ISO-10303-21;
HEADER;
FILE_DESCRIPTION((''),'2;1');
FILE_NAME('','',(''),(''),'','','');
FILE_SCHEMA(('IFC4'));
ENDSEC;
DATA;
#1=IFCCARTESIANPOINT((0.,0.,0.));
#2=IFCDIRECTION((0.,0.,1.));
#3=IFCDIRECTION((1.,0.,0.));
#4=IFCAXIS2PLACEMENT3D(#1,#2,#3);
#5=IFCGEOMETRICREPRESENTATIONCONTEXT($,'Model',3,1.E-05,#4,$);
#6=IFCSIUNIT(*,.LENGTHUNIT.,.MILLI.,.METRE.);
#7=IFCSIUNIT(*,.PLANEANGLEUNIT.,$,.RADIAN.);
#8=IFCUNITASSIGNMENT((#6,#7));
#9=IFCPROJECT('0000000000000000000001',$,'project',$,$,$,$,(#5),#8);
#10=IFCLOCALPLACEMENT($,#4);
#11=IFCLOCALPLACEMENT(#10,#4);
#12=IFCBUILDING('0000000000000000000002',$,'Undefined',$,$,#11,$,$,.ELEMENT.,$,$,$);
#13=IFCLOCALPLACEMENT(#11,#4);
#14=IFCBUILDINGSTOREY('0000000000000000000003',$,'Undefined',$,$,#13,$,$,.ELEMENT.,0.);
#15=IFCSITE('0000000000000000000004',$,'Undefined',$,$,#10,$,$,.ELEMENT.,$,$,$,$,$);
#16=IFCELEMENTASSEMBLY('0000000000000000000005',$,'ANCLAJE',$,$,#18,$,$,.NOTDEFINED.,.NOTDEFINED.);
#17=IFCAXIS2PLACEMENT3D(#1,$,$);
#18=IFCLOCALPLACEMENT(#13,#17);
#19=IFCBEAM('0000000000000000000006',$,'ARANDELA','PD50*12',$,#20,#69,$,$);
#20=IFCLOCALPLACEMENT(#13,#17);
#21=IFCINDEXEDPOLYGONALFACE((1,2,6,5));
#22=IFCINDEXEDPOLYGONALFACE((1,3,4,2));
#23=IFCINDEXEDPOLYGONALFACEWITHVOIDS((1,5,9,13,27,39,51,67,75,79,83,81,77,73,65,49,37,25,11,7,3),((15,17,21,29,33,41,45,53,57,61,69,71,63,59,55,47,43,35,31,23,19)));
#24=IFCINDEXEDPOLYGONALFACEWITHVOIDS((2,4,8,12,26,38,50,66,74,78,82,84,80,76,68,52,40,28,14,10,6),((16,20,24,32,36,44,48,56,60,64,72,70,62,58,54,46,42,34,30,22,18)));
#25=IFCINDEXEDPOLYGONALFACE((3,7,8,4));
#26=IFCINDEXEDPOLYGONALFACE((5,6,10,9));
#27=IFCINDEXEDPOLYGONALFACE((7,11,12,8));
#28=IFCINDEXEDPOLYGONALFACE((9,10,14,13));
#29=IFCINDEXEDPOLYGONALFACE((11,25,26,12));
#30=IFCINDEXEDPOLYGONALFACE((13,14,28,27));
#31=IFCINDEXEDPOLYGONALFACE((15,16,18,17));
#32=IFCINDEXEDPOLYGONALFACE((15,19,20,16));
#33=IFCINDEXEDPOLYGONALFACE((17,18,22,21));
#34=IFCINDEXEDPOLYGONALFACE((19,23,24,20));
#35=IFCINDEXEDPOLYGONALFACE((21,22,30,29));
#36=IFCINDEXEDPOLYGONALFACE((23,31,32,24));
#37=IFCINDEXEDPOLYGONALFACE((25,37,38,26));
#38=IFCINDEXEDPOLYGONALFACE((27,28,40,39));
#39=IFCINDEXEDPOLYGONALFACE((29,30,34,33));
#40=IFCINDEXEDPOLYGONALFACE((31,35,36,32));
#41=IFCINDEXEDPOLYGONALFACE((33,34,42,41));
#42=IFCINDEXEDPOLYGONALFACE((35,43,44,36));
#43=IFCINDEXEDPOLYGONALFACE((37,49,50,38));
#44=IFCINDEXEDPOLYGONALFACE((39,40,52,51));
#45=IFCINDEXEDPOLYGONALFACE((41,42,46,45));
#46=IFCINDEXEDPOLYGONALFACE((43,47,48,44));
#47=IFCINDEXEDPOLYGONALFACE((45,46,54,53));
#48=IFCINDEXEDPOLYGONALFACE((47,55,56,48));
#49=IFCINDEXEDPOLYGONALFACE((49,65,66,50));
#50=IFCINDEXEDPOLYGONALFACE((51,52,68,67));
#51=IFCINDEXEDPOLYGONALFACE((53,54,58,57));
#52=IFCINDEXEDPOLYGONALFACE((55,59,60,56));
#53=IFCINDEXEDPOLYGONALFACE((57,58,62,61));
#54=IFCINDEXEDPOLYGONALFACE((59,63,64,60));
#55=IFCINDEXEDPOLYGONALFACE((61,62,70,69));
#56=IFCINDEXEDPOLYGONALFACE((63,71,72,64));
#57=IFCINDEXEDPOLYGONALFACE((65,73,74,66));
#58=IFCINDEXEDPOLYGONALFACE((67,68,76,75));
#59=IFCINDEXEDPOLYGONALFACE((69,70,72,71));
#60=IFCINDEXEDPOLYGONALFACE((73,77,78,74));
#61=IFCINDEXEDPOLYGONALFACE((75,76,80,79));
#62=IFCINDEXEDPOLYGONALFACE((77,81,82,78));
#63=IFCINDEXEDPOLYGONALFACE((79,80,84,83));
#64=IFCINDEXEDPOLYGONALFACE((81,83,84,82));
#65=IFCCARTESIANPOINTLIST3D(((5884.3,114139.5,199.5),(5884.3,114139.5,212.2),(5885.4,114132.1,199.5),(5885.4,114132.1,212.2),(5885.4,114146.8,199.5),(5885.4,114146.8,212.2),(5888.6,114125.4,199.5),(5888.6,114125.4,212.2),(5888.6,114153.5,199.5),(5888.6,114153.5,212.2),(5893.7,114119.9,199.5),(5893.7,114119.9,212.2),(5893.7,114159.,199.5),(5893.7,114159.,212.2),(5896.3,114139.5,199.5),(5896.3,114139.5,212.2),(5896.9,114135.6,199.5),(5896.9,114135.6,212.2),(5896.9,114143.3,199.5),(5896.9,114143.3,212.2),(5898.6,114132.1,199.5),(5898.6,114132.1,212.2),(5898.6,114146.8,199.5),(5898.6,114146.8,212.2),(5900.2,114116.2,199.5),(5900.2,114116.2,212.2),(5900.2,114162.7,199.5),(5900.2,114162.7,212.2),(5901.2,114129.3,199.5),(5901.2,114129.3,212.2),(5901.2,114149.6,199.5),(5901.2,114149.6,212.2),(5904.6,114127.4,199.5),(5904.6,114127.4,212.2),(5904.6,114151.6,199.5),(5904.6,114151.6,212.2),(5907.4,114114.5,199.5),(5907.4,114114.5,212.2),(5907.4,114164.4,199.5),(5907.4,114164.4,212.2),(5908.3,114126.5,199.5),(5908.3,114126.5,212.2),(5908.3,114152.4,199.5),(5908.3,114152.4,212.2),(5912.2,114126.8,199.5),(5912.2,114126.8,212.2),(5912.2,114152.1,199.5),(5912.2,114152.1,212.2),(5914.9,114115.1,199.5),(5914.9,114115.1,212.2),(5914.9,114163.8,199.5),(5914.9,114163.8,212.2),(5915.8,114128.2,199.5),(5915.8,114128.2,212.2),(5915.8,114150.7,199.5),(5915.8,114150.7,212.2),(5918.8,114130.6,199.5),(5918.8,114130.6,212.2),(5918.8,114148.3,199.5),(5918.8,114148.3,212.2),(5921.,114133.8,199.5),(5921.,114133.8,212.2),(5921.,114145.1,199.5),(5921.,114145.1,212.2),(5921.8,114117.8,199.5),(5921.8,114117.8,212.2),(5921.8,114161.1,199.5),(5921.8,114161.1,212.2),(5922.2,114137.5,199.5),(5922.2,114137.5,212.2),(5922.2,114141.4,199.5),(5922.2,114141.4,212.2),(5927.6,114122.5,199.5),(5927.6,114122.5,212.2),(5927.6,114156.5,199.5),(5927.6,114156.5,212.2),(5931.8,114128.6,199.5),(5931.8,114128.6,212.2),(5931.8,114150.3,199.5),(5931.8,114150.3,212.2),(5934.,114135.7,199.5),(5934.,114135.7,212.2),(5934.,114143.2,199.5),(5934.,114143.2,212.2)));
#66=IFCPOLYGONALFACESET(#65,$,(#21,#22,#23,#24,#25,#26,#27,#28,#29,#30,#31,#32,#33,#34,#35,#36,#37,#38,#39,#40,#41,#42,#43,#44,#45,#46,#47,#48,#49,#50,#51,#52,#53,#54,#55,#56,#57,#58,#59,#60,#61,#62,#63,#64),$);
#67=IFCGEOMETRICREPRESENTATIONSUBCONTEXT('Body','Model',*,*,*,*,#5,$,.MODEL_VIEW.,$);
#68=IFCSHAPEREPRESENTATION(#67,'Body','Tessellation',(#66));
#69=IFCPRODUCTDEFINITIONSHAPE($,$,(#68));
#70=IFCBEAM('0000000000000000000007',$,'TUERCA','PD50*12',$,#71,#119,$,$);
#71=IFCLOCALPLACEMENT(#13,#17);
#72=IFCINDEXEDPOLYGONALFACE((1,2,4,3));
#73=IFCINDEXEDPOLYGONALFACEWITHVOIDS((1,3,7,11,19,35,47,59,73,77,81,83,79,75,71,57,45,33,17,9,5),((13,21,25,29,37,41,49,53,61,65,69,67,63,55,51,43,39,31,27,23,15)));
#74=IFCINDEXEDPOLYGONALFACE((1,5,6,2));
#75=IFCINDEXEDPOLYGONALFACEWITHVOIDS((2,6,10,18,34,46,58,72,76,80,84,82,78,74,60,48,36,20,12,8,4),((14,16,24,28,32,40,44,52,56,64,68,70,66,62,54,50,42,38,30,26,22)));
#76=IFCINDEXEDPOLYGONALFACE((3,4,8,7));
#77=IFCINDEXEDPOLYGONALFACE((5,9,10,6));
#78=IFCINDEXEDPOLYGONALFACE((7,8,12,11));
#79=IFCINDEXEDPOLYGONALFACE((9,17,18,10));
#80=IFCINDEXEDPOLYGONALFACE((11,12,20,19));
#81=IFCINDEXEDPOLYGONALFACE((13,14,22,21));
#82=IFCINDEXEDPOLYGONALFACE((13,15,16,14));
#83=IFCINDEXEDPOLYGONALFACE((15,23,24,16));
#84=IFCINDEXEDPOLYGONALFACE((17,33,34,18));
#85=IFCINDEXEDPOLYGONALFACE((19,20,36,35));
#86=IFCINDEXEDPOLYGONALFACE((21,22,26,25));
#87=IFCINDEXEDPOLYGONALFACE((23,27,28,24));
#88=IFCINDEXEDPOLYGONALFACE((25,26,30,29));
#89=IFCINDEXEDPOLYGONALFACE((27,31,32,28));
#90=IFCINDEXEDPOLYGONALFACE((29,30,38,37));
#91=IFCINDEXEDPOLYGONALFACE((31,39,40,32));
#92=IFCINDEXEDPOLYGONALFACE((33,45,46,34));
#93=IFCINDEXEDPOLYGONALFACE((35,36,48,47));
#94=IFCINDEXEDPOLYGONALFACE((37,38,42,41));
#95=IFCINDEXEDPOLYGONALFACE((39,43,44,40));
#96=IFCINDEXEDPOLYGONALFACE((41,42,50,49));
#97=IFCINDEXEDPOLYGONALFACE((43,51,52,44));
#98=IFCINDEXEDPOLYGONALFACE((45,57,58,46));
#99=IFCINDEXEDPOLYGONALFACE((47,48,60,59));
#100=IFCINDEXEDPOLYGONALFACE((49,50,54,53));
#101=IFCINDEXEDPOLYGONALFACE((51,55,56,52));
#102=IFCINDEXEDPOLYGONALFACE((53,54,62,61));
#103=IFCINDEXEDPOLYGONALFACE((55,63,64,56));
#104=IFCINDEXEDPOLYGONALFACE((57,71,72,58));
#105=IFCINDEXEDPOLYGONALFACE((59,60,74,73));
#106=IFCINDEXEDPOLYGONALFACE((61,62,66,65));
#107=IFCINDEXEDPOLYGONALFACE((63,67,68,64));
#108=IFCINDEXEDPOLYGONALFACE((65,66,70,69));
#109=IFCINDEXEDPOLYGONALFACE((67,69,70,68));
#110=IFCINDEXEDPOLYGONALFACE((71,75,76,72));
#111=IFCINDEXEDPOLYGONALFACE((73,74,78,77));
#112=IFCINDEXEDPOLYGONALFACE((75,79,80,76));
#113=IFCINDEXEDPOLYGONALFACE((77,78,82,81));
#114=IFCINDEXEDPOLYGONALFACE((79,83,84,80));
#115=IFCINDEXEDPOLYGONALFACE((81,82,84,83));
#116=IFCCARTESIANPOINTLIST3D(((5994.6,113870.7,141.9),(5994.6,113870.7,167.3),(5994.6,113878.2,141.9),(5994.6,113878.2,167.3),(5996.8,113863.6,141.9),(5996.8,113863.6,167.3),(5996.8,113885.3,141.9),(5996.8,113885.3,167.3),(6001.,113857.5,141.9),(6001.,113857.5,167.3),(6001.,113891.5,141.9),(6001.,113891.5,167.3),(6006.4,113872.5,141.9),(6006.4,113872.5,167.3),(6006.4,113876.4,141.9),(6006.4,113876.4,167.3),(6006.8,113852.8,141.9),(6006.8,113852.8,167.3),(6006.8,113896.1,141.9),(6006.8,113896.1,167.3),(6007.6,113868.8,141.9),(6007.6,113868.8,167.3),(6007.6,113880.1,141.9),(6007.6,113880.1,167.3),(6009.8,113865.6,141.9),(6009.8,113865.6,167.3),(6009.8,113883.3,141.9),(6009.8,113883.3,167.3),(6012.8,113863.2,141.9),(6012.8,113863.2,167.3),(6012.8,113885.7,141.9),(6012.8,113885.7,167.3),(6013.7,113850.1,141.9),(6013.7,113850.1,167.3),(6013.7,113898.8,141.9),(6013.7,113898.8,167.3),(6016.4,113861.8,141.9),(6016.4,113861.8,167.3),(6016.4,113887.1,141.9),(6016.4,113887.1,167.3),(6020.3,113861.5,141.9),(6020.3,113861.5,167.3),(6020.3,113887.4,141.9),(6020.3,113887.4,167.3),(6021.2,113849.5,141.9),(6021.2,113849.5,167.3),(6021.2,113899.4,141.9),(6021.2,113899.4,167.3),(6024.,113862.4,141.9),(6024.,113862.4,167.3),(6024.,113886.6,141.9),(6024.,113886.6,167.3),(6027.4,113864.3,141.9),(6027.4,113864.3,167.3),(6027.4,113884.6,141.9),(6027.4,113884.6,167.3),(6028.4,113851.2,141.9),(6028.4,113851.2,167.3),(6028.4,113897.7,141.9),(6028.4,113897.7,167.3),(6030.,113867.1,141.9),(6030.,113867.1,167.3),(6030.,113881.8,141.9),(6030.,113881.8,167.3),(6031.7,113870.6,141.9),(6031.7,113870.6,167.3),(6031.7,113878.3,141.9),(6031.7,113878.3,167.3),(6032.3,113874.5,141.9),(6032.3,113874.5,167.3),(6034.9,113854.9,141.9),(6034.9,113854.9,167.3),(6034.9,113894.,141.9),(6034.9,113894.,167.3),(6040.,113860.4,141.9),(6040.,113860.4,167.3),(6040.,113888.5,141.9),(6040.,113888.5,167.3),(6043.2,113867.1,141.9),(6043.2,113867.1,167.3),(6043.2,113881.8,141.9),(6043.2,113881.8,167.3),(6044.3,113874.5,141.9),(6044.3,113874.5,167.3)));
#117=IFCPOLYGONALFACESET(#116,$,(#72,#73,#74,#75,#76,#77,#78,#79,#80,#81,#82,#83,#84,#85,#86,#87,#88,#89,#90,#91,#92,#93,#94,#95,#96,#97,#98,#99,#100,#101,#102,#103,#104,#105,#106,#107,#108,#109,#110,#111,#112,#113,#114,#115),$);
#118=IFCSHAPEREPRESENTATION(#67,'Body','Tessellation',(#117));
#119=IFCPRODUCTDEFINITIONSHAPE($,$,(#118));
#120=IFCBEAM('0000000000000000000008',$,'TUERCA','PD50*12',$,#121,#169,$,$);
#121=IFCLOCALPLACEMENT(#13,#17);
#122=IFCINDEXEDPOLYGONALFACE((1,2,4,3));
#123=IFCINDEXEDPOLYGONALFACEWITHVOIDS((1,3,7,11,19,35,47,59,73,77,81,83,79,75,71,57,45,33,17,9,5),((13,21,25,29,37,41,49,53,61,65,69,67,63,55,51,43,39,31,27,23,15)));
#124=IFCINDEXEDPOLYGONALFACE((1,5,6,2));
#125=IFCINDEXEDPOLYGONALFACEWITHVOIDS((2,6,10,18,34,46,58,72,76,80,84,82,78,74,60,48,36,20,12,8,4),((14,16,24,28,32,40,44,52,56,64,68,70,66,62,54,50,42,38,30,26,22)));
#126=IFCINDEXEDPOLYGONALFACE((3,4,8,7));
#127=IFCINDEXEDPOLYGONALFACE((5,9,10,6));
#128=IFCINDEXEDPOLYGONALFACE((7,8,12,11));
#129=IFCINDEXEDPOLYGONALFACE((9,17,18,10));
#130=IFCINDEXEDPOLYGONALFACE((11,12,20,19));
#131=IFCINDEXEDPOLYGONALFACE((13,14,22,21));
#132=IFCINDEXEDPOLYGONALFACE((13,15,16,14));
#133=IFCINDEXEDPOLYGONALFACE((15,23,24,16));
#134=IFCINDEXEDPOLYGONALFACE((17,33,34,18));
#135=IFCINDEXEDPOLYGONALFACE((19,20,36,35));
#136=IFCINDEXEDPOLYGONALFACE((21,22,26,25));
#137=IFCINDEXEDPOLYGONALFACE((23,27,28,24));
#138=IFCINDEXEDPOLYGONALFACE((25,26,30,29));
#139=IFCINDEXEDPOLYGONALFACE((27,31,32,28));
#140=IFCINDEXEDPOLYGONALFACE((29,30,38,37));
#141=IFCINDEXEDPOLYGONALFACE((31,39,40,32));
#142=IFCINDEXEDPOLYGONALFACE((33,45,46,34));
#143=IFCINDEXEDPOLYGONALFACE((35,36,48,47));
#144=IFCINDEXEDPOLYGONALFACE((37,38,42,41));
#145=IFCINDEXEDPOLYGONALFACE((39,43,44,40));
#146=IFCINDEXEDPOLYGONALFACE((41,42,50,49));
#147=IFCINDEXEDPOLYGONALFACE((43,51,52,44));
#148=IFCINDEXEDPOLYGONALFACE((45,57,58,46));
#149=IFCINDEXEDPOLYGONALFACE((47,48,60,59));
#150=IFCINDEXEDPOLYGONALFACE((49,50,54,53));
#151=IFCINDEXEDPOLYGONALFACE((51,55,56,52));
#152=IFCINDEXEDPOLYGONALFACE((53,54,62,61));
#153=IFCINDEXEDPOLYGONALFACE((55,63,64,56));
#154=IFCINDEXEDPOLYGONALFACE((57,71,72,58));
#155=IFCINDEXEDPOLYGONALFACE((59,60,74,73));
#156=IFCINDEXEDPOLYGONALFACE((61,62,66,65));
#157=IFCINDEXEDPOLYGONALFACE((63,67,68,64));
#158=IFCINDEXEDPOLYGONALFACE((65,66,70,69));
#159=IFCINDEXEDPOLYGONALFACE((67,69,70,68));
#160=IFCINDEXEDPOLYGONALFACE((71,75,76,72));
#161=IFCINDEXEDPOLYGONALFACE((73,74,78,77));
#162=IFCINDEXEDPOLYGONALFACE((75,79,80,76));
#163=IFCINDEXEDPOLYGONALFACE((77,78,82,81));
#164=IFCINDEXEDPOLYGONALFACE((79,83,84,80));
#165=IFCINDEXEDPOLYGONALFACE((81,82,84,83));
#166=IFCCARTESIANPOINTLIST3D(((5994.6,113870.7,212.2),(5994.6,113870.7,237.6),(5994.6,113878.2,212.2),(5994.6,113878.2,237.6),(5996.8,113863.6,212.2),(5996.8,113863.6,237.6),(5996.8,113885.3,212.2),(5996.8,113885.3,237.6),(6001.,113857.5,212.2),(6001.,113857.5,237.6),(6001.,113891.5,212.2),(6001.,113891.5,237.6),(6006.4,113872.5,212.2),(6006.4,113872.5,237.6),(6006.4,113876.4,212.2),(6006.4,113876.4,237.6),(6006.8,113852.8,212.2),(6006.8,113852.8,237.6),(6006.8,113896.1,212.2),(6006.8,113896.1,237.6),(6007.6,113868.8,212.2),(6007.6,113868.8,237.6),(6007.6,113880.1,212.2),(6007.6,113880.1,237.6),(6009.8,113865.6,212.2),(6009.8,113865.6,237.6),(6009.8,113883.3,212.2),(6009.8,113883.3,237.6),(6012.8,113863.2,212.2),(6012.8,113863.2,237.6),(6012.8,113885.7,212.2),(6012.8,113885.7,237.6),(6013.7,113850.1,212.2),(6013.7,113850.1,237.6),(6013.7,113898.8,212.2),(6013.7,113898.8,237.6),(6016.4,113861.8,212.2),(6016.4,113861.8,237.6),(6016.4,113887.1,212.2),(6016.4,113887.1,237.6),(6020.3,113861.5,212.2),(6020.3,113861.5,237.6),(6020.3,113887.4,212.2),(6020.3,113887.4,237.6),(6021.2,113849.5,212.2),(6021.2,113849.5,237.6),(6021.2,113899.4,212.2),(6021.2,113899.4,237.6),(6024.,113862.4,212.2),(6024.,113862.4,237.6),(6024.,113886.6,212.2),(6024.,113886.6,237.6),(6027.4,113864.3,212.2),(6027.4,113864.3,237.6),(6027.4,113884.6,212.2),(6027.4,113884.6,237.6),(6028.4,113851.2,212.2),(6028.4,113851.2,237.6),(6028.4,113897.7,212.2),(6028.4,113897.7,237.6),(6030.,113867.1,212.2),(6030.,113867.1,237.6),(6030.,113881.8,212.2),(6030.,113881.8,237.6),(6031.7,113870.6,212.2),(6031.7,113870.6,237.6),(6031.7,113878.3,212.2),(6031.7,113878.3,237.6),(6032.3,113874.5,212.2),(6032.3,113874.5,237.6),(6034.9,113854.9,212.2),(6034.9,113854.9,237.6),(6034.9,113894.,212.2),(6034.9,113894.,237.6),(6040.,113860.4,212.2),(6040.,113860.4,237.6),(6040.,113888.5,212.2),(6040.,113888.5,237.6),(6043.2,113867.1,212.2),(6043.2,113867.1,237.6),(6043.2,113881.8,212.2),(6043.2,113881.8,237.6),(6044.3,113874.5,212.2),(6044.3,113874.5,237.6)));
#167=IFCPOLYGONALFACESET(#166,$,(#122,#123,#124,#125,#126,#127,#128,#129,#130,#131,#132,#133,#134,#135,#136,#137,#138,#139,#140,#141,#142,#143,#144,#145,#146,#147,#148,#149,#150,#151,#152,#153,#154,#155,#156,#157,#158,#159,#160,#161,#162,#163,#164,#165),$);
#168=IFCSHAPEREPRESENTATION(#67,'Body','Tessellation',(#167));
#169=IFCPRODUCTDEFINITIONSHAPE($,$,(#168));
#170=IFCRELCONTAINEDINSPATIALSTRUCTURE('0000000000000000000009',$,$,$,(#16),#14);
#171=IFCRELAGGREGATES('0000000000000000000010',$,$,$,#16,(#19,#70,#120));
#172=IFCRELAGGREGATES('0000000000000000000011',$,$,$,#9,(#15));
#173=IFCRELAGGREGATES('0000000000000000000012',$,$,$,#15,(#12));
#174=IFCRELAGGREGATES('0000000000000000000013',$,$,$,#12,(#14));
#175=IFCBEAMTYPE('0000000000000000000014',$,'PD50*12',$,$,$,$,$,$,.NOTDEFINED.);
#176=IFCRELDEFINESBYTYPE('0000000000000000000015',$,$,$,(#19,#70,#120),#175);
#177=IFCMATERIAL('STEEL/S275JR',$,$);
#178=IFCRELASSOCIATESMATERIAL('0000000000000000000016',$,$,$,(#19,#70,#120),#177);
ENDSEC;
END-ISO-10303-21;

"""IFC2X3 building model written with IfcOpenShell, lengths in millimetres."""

from ifc_helpers import new_model, si_unit, frame, origin_with_axes, origin_2d_with_axis, place, context, subcontext, project, spatial, hollow_circle, extrude, material, type_object, element, aggregate, save


model = new_model("IFC2X3")

# Units and contexts
model_context = context("Model", 3, precision=1e-05, world=origin_with_axes())
body_context = subcontext(model_context, "Body", "Model", "MODEL_VIEW")
ifc_project = project(units=[si_unit("LENGTHUNIT", "METRE", prefix="MILLI"), si_unit("PLANEANGLEUNIT", "RADIAN")], contexts=[model_context])

# Site, building, storey
site_placement = place(None, origin_with_axes())
site = spatial("IfcSite", under=ifc_project, at=site_placement, Name="Undefined", CompositionType="ELEMENT")
building_placement = place(site_placement, origin_with_axes())
building = spatial("IfcBuilding", under=site, at=building_placement, Name="Undefined", CompositionType="ELEMENT")
storey_placement = place(building_placement, origin_with_axes())
storey = spatial("IfcBuildingStorey", under=building, at=storey_placement, Name="Undefined", CompositionType="ELEMENT", Elevation=0.0)

# Element assembly, beams
assembly_1_placement = place(storey_placement, origin_with_axes())
assembly_1 = element("IfcElementAssembly", 1, at=assembly_1_placement, inside=storey, Name="ANCLAJE", AssemblyPlace="NOTDEFINED", PredefinedType="NOTDEFINED")
ifc_material_1 = material(Name="STEEL/S275JR")
beam_type_1 = type_object("IfcBeamType", Name="PD50*12", PredefinedType="NOTDEFINED")
beam_1_placement = place(assembly_1_placement, frame((5909.3, 114139.5, 212.2), z_axis=(0.0, -1.0, 0.0), x_axis=(0.0, 0.0, -1.0)))
beam_1 = element("IfcBeam", 2, at=beam_1_placement, type_object=beam_type_1, material=ifc_material_1, Name="ARANDELA", Description="PD50*12", context=body_context, shape_type="SweptSolid", body=[
    extrude(hollow_circle(Radius=25.0, WallThickness=12.0, at=origin_2d_with_axis()), frame((12.7, 0.0, 0.0), z_axis=(-1.0, 0.0, 0.0), x_axis=(0.0, -1.0, 0.0)), (0.0, 0.0, 1.0), 12.7),
])
beam_2_placement = place(assembly_1_placement, frame((6019.3, 113874.5, 167.3), z_axis=(0.0, 1.0, 0.0), x_axis=(0.0, 0.0, -1.0)))
beam_2 = element("IfcBeam", 3, at=beam_2_placement, type_object=beam_type_1, material=ifc_material_1, Name="TUERCA", Description="PD50*12", context=body_context, shape_type="SweptSolid", body=[
    extrude(hollow_circle(Radius=25.0, WallThickness=12.0, at=origin_2d_with_axis()), frame((25.4, 0.0, 0.0), z_axis=(-1.0, 0.0, 0.0), x_axis=(0.0, -1.0, 0.0)), (0.0, 0.0, 1.0), 25.4),
])
beam_3_placement = place(assembly_1_placement, frame((6019.3, 113874.5, 237.6), z_axis=(0.0, 1.0, 0.0), x_axis=(0.0, 0.0, -1.0)))
beam_3 = element("IfcBeam", 4, at=beam_3_placement, type_object=beam_type_1, material=ifc_material_1, Name="TUERCA", Description="PD50*12", context=body_context, shape_type="SweptSolid", body=[
    extrude(hollow_circle(Radius=25.0, WallThickness=12.0, at=origin_2d_with_axis()), frame((25.4, 0.0, 0.0), z_axis=(-1.0, 0.0, 0.0), x_axis=(0.0, -1.0, 0.0)), (0.0, 0.0, 1.0), 25.4),
])

aggregate(assembly_1, [beam_1, beam_2, beam_3])

save(model, "model.ifc")
